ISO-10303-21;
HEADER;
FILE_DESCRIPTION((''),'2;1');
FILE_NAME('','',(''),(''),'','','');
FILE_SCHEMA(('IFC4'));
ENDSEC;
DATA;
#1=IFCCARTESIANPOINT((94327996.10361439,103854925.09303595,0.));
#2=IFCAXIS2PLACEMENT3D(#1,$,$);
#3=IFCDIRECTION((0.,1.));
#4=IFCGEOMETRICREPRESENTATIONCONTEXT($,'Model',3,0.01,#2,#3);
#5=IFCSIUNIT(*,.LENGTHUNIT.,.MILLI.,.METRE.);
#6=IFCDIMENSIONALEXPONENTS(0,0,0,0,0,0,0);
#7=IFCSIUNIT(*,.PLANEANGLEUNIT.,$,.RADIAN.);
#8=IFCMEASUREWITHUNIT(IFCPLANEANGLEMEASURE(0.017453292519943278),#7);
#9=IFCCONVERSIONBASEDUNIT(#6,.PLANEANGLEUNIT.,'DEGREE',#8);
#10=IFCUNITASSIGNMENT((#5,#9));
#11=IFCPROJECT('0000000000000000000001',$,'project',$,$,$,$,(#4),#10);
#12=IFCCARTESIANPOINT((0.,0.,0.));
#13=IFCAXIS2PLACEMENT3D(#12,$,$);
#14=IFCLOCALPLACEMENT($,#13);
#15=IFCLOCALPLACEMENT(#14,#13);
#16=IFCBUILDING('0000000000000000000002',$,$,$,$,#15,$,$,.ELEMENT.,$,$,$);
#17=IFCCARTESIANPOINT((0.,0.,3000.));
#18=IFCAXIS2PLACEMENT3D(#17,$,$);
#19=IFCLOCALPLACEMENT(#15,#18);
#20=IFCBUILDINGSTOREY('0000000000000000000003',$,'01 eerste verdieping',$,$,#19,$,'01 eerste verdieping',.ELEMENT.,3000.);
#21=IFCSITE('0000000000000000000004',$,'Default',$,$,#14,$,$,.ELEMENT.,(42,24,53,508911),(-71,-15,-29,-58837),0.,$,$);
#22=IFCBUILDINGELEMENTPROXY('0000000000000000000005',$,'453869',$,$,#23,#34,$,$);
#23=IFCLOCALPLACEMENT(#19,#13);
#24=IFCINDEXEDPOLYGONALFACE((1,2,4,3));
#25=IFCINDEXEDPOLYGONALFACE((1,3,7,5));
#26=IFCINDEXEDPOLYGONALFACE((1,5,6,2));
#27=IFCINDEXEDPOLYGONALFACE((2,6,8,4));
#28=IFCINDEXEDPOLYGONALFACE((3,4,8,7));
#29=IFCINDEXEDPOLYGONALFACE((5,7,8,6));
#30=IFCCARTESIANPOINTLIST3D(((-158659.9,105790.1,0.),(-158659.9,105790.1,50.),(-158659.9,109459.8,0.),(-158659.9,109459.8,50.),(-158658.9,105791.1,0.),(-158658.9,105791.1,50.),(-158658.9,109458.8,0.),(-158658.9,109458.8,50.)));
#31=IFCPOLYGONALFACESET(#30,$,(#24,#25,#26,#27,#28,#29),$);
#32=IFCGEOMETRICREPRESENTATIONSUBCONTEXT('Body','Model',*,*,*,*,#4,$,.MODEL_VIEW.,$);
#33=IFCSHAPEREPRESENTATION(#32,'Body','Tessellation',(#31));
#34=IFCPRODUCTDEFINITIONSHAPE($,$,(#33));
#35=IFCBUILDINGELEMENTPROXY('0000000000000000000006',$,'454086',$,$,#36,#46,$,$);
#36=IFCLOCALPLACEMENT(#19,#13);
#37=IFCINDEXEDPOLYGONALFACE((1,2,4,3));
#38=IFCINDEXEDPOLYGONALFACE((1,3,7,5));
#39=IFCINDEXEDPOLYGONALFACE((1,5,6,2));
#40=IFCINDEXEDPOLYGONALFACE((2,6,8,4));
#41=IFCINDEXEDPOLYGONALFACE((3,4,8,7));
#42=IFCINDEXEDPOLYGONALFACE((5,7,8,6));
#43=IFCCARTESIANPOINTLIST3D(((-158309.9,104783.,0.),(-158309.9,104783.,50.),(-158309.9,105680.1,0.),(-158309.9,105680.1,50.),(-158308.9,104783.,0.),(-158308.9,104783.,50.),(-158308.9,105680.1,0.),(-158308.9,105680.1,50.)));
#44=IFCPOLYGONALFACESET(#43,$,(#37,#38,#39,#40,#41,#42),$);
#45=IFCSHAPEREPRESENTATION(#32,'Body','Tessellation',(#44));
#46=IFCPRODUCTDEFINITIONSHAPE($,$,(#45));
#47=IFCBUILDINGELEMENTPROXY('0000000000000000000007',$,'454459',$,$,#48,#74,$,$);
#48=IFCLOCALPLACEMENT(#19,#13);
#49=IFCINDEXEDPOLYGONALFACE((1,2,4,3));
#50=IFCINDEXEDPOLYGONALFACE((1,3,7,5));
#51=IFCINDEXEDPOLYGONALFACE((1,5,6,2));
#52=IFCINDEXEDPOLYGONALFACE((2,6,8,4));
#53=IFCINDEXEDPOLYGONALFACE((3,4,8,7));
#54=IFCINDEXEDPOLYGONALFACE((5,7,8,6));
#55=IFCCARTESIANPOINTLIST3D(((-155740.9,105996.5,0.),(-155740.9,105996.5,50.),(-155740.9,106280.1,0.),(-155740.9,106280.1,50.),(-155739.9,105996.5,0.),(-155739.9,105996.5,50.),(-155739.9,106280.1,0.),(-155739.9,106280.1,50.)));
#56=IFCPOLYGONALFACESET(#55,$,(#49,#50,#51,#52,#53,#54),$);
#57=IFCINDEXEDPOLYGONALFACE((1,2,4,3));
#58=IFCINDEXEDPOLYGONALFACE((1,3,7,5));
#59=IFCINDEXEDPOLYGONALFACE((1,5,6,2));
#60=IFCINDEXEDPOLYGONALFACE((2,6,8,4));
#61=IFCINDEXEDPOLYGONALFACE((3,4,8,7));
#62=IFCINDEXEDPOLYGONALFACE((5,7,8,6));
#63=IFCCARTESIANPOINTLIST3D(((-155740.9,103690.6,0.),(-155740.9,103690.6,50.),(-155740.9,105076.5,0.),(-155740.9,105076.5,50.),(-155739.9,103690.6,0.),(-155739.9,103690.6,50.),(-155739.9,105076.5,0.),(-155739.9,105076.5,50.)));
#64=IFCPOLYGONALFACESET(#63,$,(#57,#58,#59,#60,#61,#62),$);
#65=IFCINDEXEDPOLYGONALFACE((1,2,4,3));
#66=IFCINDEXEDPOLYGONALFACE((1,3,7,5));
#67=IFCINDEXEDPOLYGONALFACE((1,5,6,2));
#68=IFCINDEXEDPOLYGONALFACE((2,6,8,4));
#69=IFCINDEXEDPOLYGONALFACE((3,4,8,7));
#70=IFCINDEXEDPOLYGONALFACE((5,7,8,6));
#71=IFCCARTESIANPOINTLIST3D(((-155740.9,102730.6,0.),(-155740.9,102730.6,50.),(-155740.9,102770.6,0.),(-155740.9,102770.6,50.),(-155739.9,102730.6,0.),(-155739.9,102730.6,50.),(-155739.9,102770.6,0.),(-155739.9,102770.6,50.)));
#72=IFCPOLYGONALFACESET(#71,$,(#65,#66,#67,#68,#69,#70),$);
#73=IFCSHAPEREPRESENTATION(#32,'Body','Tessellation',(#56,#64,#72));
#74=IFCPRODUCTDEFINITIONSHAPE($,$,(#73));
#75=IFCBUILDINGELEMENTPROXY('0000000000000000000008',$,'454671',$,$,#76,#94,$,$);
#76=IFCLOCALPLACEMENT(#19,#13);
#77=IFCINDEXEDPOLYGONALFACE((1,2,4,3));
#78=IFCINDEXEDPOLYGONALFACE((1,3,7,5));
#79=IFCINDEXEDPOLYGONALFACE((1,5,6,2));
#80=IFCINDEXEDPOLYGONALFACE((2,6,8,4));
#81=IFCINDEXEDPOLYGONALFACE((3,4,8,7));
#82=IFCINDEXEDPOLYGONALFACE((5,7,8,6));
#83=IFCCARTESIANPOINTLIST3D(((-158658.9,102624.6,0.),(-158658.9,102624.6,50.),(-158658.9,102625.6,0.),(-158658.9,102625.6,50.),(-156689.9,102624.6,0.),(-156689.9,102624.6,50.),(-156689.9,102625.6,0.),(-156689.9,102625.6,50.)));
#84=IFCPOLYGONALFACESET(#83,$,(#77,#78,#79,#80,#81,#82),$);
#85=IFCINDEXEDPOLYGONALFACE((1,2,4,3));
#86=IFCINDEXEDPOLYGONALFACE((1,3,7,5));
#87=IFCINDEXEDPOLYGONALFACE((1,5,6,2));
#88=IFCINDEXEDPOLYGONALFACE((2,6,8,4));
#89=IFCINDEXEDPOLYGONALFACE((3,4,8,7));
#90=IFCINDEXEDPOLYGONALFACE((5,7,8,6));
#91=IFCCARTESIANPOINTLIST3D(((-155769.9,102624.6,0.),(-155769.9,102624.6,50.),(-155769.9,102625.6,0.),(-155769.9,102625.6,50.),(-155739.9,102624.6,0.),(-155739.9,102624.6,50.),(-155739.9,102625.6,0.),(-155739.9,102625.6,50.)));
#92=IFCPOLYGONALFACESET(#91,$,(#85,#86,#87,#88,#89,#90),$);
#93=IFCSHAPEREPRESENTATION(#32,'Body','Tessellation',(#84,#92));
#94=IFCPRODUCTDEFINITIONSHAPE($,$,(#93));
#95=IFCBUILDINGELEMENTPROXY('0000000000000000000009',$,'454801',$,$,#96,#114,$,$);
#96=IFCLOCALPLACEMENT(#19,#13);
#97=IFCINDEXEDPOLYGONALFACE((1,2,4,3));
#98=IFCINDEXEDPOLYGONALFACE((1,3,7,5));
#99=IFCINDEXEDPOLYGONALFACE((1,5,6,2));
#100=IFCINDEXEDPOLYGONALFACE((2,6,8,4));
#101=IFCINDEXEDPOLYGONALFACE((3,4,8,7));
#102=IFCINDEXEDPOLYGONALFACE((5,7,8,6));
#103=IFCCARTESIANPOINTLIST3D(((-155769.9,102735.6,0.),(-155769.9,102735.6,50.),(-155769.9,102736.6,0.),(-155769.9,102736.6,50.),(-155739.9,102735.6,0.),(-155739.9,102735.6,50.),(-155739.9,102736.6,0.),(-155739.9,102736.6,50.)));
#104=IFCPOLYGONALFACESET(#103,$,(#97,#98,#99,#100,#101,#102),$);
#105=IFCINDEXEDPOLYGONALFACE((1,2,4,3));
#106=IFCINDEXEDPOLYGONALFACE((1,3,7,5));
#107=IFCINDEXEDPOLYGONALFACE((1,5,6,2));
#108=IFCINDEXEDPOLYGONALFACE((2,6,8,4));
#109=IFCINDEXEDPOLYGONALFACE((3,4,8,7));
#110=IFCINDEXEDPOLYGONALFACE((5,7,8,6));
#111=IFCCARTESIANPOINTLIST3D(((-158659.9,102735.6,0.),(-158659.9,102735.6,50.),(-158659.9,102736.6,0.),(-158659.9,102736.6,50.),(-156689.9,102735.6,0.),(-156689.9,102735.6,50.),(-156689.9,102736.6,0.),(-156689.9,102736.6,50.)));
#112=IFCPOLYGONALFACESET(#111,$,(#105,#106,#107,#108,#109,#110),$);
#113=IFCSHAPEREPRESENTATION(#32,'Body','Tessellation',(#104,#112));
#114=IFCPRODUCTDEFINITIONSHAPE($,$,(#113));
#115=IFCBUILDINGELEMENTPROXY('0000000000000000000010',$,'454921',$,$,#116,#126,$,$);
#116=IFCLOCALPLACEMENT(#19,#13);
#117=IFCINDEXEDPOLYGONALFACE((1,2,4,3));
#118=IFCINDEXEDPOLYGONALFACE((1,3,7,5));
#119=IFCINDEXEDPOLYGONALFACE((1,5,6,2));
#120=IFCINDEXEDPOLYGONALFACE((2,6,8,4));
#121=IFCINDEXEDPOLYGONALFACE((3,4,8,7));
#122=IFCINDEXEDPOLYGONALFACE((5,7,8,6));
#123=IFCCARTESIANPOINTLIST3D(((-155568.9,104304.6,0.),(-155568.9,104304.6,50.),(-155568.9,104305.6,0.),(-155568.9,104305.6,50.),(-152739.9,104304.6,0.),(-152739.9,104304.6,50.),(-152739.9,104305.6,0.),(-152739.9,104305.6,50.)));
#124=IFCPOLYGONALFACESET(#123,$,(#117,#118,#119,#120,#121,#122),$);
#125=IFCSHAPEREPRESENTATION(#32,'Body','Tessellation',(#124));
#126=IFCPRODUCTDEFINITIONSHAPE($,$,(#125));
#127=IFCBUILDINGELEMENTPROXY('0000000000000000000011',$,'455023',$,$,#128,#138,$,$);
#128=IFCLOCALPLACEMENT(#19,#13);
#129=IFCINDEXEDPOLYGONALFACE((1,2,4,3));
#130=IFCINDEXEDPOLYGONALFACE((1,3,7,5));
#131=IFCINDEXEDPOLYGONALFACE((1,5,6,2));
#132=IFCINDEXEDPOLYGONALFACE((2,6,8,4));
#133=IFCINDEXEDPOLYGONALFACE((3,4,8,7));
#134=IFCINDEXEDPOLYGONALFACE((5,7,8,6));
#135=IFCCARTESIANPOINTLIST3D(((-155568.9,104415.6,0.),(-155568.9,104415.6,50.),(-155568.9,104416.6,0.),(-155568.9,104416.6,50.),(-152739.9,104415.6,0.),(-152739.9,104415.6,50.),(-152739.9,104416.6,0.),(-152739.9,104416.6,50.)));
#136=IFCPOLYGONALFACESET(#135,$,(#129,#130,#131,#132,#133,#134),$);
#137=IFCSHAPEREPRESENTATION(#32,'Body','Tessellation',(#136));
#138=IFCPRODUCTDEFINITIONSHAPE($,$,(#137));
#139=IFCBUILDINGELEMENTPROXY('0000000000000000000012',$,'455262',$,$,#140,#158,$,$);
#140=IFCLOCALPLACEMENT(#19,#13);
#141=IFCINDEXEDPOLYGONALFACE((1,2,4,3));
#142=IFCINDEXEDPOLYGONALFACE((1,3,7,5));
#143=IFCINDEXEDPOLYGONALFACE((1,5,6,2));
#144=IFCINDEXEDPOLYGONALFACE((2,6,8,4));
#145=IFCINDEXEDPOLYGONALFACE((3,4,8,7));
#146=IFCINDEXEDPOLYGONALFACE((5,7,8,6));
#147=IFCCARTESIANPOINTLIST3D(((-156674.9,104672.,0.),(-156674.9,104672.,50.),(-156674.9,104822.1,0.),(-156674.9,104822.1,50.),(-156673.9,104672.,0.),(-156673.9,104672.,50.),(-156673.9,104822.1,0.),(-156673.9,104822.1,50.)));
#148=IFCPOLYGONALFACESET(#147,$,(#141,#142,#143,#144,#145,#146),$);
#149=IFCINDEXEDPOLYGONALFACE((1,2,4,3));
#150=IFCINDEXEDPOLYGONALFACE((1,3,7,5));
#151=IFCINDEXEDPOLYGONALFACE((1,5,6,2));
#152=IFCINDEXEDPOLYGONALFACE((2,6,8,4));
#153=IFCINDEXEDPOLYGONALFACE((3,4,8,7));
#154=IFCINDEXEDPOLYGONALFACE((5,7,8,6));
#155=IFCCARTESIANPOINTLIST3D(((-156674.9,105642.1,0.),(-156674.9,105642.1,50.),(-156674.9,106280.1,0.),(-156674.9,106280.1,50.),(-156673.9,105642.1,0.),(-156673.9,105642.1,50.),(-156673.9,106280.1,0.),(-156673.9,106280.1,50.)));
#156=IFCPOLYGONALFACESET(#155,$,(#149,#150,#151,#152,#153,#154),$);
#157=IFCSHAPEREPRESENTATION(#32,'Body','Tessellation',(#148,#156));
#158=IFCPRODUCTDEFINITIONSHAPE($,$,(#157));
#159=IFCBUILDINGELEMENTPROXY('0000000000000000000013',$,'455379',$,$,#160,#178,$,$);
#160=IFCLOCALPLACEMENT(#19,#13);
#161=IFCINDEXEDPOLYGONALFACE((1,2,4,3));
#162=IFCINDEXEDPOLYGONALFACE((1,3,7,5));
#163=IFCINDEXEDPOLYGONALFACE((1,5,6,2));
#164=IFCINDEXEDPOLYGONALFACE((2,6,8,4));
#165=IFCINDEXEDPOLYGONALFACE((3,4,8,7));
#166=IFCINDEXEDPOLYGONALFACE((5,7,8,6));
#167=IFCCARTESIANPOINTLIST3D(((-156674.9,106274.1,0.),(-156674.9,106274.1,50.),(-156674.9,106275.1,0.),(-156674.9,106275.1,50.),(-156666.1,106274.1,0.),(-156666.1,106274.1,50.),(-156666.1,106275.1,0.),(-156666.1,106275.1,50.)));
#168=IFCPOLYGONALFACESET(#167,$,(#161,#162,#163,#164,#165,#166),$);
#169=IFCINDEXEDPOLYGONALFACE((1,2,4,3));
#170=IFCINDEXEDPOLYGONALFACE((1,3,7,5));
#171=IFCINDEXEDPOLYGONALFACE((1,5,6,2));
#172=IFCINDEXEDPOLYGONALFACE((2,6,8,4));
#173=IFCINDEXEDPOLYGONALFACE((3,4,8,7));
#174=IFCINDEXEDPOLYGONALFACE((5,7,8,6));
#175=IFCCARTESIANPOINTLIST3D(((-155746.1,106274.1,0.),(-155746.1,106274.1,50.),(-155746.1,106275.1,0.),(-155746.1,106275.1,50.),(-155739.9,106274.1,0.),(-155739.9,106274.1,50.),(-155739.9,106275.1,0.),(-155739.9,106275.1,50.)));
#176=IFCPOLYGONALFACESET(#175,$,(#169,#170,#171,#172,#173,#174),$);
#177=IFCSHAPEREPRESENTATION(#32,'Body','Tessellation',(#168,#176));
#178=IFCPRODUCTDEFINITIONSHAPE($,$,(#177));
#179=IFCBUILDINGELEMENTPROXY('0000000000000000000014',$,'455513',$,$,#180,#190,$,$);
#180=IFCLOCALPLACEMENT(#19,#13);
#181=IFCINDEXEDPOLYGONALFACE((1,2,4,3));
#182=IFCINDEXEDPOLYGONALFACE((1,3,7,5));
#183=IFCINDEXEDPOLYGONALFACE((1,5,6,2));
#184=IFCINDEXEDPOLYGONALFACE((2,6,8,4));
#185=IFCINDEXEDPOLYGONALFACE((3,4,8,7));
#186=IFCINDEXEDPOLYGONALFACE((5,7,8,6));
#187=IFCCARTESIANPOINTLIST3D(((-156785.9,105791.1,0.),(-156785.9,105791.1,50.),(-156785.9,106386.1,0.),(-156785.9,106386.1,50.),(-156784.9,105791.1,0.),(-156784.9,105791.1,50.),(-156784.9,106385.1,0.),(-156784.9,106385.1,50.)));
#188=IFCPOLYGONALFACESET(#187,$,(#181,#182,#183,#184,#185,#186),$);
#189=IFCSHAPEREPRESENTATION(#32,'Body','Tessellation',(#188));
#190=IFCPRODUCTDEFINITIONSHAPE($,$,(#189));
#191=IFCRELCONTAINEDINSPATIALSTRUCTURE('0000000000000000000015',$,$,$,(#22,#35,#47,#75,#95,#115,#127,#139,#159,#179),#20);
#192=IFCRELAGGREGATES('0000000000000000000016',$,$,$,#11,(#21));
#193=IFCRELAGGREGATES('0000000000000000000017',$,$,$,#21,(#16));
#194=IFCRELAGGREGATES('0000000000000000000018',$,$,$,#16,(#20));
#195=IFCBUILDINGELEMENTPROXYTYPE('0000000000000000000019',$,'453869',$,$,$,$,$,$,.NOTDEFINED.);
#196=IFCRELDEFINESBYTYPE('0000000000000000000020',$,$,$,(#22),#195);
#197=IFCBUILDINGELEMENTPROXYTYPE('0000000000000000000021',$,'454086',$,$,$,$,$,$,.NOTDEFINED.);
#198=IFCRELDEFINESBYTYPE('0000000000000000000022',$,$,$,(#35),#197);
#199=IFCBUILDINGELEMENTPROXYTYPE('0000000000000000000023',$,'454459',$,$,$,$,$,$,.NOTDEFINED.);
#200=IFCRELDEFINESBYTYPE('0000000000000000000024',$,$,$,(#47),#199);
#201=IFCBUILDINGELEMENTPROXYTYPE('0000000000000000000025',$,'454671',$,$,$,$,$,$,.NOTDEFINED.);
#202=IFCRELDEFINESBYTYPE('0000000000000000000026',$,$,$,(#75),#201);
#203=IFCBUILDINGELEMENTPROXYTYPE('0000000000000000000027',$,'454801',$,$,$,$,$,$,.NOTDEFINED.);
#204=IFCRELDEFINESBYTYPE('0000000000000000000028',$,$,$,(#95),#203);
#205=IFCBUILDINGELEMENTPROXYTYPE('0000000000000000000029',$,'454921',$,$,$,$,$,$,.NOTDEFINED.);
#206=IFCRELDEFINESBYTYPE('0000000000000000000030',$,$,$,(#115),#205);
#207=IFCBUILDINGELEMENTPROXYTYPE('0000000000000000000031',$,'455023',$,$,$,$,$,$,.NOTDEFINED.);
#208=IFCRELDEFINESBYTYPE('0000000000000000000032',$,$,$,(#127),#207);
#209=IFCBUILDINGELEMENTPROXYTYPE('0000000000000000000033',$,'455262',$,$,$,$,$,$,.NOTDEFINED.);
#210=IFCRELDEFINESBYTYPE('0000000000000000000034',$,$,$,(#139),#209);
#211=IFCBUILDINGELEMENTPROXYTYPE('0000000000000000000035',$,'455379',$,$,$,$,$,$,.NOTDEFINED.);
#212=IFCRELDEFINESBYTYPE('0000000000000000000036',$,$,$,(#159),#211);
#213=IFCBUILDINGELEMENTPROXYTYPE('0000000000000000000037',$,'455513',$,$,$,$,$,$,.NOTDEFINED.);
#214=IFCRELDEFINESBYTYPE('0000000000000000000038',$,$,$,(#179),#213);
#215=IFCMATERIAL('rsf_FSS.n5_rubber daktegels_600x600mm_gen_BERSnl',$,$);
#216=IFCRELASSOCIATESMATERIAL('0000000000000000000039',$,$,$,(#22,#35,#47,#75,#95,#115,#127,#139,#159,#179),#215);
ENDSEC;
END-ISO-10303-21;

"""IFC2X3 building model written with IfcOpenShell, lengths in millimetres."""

from ifc_helpers import new_model, entity, si_unit, converted_unit, direction, frame, frame_2d, origin, origin_2d_with_axis, place, context, subcontext, project, spatial, polyline, rectangle, outline, extrude, material, type_object, element, save


model = new_model("IFC2X3")

# Units and contexts
model_context = context("Model", 3, precision=0.01, world=frame((94327996.10361439, 103854925.09303595, 0.0)), true_north=direction((0.0, 1.0)))
body_context = subcontext(model_context, "Body", "Model", "MODEL_VIEW")
ifc_project = project(units=[si_unit("LENGTHUNIT", "METRE", prefix="MILLI"), converted_unit("PLANEANGLEUNIT", "DEGREE", entity("IfcPlaneAngleMeasure", 0.017453292519943278), si_unit("PLANEANGLEUNIT", "RADIAN"), dimensions=[0, 0, 0, 0, 0, 0, 0])], contexts=[model_context])

# Site, building, storey
site_placement = place(None, origin())
site = spatial("IfcSite", under=ifc_project, at=site_placement, Name="Default", CompositionType="ELEMENT", RefLatitude=(42, 24, 53, 508911), RefLongitude=(-71, -15, -29, -58837), RefElevation=0.0)
building_placement = place(site_placement, origin())
building = spatial("IfcBuilding", under=site, at=building_placement, CompositionType="ELEMENT")
storey_placement = place(building_placement, frame((0.0, 0.0, 3000.0)))
storey = spatial("IfcBuildingStorey", under=building, at=storey_placement, Name="01 eerste verdieping", LongName="01 eerste verdieping", CompositionType="ELEMENT", Elevation=3000.0)

# Building element proxies
ifc_material = material(Name="rsf_FSS.n5_rubber daktegels_600x600mm_gen_BERSnl")
building_element_proxy_type_1 = type_object("IfcBuildingElementProxyType", Name="453869", PredefinedType="NOTDEFINED")
proxy_1_placement = place(storey_placement, origin())
element("IfcBuildingElementProxy", 1, at=proxy_1_placement, inside=storey, type_object=building_element_proxy_type_1, material=ifc_material, Name="453869", context=body_context, shape_type="SweptSolid", body=[
    extrude(outline(polyline([(-1834.8, -0.5), (1834.8, -0.5), (1833.8, 0.5), (-1833.8, 0.5), (-1834.8, -0.5)])), frame((-158659.4, 107625.0, 0.0), z_axis=(0.0, 0.0, 1.0), x_axis=(0.0, -1.0, 0.0)), (0.0, 0.0, 1.0), 50.0),
])
building_element_proxy_type_2 = type_object("IfcBuildingElementProxyType", Name="454086", PredefinedType="NOTDEFINED")
proxy_2_placement = place(storey_placement, origin())
element("IfcBuildingElementProxy", 2, at=proxy_2_placement, inside=storey, type_object=building_element_proxy_type_2, material=ifc_material, Name="454086", context=body_context, shape_type="SweptSolid", body=[
    extrude(rectangle(XDim=897.2, YDim=1.0, at=frame_2d((0.0, 0.0), x_axis=(1.0, 0.0))), frame((-158309.4, 105231.5, 0.0), z_axis=(0.0, 0.0, 1.0), x_axis=(0.0, -1.0, 0.0)), (0.0, 0.0, 1.0), 50.0),
])
building_element_proxy_type_3 = type_object("IfcBuildingElementProxyType", Name="454459", PredefinedType="NOTDEFINED")
proxy_3_placement = place(storey_placement, origin())
element("IfcBuildingElementProxy", 3, at=proxy_3_placement, inside=storey, type_object=building_element_proxy_type_3, material=ifc_material, Name="454459", context=body_context, shape_type="SweptSolid", body=[
    extrude(rectangle(XDim=283.6, YDim=1.0, at=frame_2d((0.0, 0.0), x_axis=(1.0, 0.0))), frame((-155740.4, 106138.3, 0.0), z_axis=(0.0, 0.0, 1.0), x_axis=(0.0, 1.0, 0.0)), (0.0, 0.0, 1.0), 50.0),
    extrude(rectangle(XDim=1385.9, YDim=1.0, at=frame_2d((0.0, 0.0), x_axis=(1.0, 0.0))), frame((-155740.4, 104383.6, 0.0), z_axis=(0.0, 0.0, 1.0), x_axis=(0.0, 1.0, 0.0)), (0.0, 0.0, 1.0), 50.0),
    extrude(rectangle(XDim=40.0, YDim=1.0, at=frame_2d((0.0, 0.0), x_axis=(1.0, 0.0))), frame((-155740.4, 102750.6, 0.0), z_axis=(0.0, 0.0, 1.0), x_axis=(0.0, 1.0, 0.0)), (0.0, 0.0, 1.0), 50.0),
])
building_element_proxy_type_4 = type_object("IfcBuildingElementProxyType", Name="454671", PredefinedType="NOTDEFINED")
proxy_4_placement = place(storey_placement, origin())
element("IfcBuildingElementProxy", 4, at=proxy_4_placement, inside=storey, type_object=building_element_proxy_type_4, material=ifc_material, Name="454671", context=body_context, shape_type="SweptSolid", body=[
    extrude(rectangle(XDim=1969.0, YDim=1.0, at=frame_2d((0.0, 0.0), x_axis=(1.0, 0.0))), frame((-157674.4, 102625.1, 0.0), z_axis=(0.0, 0.0, 1.0), x_axis=(-1.0, 0.0, 0.0)), (0.0, 0.0, 1.0), 50.0),
    extrude(rectangle(XDim=30.0, YDim=1.0, at=frame_2d((2.8, 0.1), x_axis=(1.0, 0.0))), frame((-155752.1, 102625.2, 0.0), z_axis=(0.0, 0.0, 1.0), x_axis=(-1.0, 0.0, 0.0)), (0.0, 0.0, 1.0), 50.0),
])
building_element_proxy_type_5 = type_object("IfcBuildingElementProxyType", Name="454801", PredefinedType="NOTDEFINED")
proxy_5_placement = place(storey_placement, origin())
element("IfcBuildingElementProxy", 5, at=proxy_5_placement, inside=storey, type_object=building_element_proxy_type_5, material=ifc_material, Name="454801", context=body_context, shape_type="SweptSolid", body=[
    extrude(rectangle(XDim=30.0, YDim=1.0, at=frame_2d((0.0, 0.0), x_axis=(1.0, 0.0))), frame((-155754.9, 102736.1, 0.0)), (0.0, 0.0, 1.0), 50.0),
    extrude(rectangle(XDim=1970.0, YDim=1.0, at=frame_2d((0.0, 0.0), x_axis=(1.0, 0.0))), frame((-157674.9, 102736.1, 0.0)), (0.0, 0.0, 1.0), 50.0),
])
building_element_proxy_type_6 = type_object("IfcBuildingElementProxyType", Name="454921", PredefinedType="NOTDEFINED")
proxy_6_placement = place(storey_placement, origin())
element("IfcBuildingElementProxy", 6, at=proxy_6_placement, inside=storey, type_object=building_element_proxy_type_6, material=ifc_material, Name="454921", context=body_context, shape_type="SweptSolid", body=[
    extrude(rectangle(XDim=2829.0, YDim=1.0, at=frame_2d((0.0, 0.0), x_axis=(1.0, 0.0))), frame((-154154.4, 104305.1, 0.0)), (0.0, 0.0, 1.0), 50.0),
])
building_element_proxy_type_7 = type_object("IfcBuildingElementProxyType", Name="455023", PredefinedType="NOTDEFINED")
proxy_7_placement = place(storey_placement, origin())
element("IfcBuildingElementProxy", 7, at=proxy_7_placement, inside=storey, type_object=building_element_proxy_type_7, material=ifc_material, Name="455023", context=body_context, shape_type="SweptSolid", body=[
    extrude(rectangle(XDim=2829.0, YDim=1.0, at=origin_2d_with_axis()), frame((-154154.4, 104416.1, 0.0), z_axis=(0.0, 0.0, 1.0), x_axis=(-1.0, 0.0, 0.0)), (0.0, 0.0, 1.0), 50.0),
])
building_element_proxy_type_8 = type_object("IfcBuildingElementProxyType", Name="455262", PredefinedType="NOTDEFINED")
proxy_8_placement = place(storey_placement, origin())
element("IfcBuildingElementProxy", 8, at=proxy_8_placement, inside=storey, type_object=building_element_proxy_type_8, material=ifc_material, Name="455262", context=body_context, shape_type="SweptSolid", body=[
    extrude(rectangle(XDim=150.2, YDim=1.0, at=frame_2d((0.0, 0.0), x_axis=(1.0, 0.0))), frame((-156674.4, 104747.0, 0.0), z_axis=(0.0, 0.0, 1.0), x_axis=(0.0, 1.0, 0.0)), (0.0, 0.0, 1.0), 50.0),
    extrude(rectangle(XDim=638.0, YDim=1.0, at=frame_2d((0.0, 0.0), x_axis=(1.0, 0.0))), frame((-156674.4, 105961.1, 0.0), z_axis=(0.0, 0.0, 1.0), x_axis=(0.0, 1.0, 0.0)), (0.0, 0.0, 1.0), 50.0),
])
building_element_proxy_type_9 = type_object("IfcBuildingElementProxyType", Name="455379", PredefinedType="NOTDEFINED")
proxy_9_placement = place(storey_placement, origin())
element("IfcBuildingElementProxy", 9, at=proxy_9_placement, inside=storey, type_object=building_element_proxy_type_9, material=ifc_material, Name="455379", context=body_context, shape_type="SweptSolid", body=[
    extrude(rectangle(XDim=8.7, YDim=1.0, at=frame_2d((0.0, 0.0), x_axis=(1.0, 0.0))), frame((-156670.5, 106274.6, 0.0)), (0.0, 0.0, 1.0), 50.0),
    extrude(rectangle(XDim=6.3, YDim=1.0, at=frame_2d((0.0, 0.0), x_axis=(1.0, 0.0))), frame((-155743.0, 106274.6, 0.0)), (0.0, 0.0, 1.0), 50.0),
])
building_element_proxy_type_10 = type_object("IfcBuildingElementProxyType", Name="455513", PredefinedType="NOTDEFINED")
proxy_10_placement = place(storey_placement, origin())
element("IfcBuildingElementProxy", 10, at=proxy_10_placement, inside=storey, type_object=building_element_proxy_type_10, material=ifc_material, Name="455513", context=body_context, shape_type="SweptSolid", body=[
    extrude(outline(polyline([(-297.2, -0.5), (296.7, -0.5), (297.7, 0.5), (-297.2, 0.5), (-297.2, -0.5)])), frame((-156785.4, 106088.4, 0.0), z_axis=(0.0, 0.0, 1.0), x_axis=(0.0, 1.0, 0.0)), (0.0, 0.0, 1.0), 50.0),
])

save(model, "model.ifc")
